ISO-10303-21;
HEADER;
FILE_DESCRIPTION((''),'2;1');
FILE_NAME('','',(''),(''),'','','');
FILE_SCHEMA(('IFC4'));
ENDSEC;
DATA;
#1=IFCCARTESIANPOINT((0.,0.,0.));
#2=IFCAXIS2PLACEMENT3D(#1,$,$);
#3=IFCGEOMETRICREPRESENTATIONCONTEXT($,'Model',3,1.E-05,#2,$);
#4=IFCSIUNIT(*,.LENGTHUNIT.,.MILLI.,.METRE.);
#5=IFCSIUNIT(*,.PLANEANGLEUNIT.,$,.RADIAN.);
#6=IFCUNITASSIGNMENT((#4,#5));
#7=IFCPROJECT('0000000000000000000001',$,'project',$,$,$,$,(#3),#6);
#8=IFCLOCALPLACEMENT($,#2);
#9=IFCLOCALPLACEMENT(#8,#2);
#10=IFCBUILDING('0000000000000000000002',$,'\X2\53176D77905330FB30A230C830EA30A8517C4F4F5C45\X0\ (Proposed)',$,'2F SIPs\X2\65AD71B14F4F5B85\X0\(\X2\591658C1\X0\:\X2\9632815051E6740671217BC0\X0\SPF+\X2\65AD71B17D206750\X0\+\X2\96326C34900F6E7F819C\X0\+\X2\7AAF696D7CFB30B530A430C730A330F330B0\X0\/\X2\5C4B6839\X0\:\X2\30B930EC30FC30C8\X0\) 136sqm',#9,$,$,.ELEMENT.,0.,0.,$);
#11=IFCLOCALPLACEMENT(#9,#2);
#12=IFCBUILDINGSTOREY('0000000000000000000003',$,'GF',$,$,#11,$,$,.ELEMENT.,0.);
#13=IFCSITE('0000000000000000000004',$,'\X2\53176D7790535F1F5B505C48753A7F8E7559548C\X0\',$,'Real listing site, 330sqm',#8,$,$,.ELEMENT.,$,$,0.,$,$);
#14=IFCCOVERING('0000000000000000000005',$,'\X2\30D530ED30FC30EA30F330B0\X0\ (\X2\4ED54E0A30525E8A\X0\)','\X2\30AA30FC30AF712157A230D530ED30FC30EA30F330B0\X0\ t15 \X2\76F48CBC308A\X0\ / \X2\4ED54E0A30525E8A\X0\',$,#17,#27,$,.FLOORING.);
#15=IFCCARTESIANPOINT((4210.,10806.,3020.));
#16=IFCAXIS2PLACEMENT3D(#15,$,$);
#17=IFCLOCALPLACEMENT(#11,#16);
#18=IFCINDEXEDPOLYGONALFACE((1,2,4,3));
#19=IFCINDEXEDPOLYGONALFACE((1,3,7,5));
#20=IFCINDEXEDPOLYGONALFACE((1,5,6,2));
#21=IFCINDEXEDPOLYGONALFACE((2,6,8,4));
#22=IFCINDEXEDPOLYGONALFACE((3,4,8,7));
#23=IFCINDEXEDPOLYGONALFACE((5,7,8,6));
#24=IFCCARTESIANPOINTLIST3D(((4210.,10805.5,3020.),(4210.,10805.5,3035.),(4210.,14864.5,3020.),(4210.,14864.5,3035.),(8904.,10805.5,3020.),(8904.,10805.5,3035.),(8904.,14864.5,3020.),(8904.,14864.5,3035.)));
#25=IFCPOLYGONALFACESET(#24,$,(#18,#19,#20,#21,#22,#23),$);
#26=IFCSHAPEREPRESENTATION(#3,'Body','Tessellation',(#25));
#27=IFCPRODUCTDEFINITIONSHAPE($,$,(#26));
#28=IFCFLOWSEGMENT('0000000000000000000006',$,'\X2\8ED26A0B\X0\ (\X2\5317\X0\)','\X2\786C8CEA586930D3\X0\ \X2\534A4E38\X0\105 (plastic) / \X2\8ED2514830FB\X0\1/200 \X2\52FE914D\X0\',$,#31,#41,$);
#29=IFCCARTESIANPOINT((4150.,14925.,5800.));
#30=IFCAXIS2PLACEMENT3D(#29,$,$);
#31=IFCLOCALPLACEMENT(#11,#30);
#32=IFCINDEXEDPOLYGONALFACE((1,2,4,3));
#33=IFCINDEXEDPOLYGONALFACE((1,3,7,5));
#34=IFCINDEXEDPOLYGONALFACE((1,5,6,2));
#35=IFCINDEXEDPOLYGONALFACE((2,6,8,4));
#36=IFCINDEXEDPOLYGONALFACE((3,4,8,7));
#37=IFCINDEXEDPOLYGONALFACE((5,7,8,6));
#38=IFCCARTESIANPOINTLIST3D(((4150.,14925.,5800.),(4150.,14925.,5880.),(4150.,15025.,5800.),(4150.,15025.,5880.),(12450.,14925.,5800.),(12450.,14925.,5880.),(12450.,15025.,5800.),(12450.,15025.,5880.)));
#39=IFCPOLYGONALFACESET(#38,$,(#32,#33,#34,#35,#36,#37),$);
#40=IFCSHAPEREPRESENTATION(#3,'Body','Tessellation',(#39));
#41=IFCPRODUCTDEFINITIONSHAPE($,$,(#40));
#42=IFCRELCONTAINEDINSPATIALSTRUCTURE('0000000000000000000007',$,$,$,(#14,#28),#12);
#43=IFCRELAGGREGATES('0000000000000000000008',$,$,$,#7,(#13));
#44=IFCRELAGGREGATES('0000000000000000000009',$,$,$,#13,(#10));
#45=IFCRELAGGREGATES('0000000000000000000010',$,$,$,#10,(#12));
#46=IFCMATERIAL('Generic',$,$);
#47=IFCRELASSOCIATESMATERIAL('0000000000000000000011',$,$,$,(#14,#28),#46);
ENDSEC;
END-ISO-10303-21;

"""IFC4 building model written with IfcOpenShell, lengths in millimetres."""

from ifc_helpers import new_model, si_unit, frame, frame_2d, origin, place, context, project, spatial, rectangle, extrude, material, element, save


model = new_model("IFC4")

# Units and contexts
model_context = context("Model", 3, precision=1e-05, world=origin())
ifc_project = project(units=[si_unit("LENGTHUNIT", "METRE", prefix="MILLI"), si_unit("PLANEANGLEUNIT", "RADIAN")], contexts=[model_context])

# Site, building, storey
site_placement = place(None, origin())
site = spatial("IfcSite", under=ifc_project, at=site_placement, Name="北海道弟子屈町美留和", ObjectType="Real listing site, 330sqm", CompositionType="ELEMENT", RefElevation=0.0)
building_placement = place(site_placement, origin())
building = spatial("IfcBuilding", under=site, at=building_placement, Name="北海道・アトリエ兼住居 (Proposed)", ObjectType="2F SIPs断熱住宅(外壁:防腐処理無節SPF+断熱素材+防水透湿膜+窯業系サイディング/屋根:スレート) 136sqm", CompositionType="ELEMENT", ElevationOfRefHeight=0.0, ElevationOfTerrain=0.0)
storey_placement = place(building_placement, origin())
storey = spatial("IfcBuildingStorey", under=building, at=storey_placement, Name="GF", CompositionType="ELEMENT", Elevation=0.0)

# Covering
ifc_material_1 = material(Name="Generic")
covering_placement = place(storey_placement, frame((4210.0, 10806.0, 3020.0)))
element("IfcCovering", 1, at=covering_placement, inside=storey, material=ifc_material_1, Name="フローリング (仕上げ床)", Description="オーク無垢フローリング t15 直貼り / 仕上げ床", PredefinedType="FLOORING", context=model_context, shape_type="SweptSolid", body=[
    extrude(rectangle(XDim=4694.0, YDim=4059.0, at=frame_2d((2347.0, 2029.0))), frame((4210.0, 10806.0, 3020.0)), (0.0, 0.0, 1.0), 15.0),
])

# Flow segment
flow_segment_placement = place(storey_placement, frame((4150.0, 14925.0, 5800.0)))
element("IfcFlowSegment", 2, at=flow_segment_placement, inside=storey, material=ifc_material_1, Name="軒樋 (北)", Description="硬質塩ビ 半丸105 (plastic) / 軒先・1/200 勾配", context=model_context, shape_type="SweptSolid", body=[
    extrude(rectangle(XDim=8300.0, YDim=100.0, at=frame_2d((4150.0, 50.0))), frame((4150.0, 14925.0, 5800.0)), (0.0, 0.0, 1.0), 80.0),
])

save(model, "model.ifc")
